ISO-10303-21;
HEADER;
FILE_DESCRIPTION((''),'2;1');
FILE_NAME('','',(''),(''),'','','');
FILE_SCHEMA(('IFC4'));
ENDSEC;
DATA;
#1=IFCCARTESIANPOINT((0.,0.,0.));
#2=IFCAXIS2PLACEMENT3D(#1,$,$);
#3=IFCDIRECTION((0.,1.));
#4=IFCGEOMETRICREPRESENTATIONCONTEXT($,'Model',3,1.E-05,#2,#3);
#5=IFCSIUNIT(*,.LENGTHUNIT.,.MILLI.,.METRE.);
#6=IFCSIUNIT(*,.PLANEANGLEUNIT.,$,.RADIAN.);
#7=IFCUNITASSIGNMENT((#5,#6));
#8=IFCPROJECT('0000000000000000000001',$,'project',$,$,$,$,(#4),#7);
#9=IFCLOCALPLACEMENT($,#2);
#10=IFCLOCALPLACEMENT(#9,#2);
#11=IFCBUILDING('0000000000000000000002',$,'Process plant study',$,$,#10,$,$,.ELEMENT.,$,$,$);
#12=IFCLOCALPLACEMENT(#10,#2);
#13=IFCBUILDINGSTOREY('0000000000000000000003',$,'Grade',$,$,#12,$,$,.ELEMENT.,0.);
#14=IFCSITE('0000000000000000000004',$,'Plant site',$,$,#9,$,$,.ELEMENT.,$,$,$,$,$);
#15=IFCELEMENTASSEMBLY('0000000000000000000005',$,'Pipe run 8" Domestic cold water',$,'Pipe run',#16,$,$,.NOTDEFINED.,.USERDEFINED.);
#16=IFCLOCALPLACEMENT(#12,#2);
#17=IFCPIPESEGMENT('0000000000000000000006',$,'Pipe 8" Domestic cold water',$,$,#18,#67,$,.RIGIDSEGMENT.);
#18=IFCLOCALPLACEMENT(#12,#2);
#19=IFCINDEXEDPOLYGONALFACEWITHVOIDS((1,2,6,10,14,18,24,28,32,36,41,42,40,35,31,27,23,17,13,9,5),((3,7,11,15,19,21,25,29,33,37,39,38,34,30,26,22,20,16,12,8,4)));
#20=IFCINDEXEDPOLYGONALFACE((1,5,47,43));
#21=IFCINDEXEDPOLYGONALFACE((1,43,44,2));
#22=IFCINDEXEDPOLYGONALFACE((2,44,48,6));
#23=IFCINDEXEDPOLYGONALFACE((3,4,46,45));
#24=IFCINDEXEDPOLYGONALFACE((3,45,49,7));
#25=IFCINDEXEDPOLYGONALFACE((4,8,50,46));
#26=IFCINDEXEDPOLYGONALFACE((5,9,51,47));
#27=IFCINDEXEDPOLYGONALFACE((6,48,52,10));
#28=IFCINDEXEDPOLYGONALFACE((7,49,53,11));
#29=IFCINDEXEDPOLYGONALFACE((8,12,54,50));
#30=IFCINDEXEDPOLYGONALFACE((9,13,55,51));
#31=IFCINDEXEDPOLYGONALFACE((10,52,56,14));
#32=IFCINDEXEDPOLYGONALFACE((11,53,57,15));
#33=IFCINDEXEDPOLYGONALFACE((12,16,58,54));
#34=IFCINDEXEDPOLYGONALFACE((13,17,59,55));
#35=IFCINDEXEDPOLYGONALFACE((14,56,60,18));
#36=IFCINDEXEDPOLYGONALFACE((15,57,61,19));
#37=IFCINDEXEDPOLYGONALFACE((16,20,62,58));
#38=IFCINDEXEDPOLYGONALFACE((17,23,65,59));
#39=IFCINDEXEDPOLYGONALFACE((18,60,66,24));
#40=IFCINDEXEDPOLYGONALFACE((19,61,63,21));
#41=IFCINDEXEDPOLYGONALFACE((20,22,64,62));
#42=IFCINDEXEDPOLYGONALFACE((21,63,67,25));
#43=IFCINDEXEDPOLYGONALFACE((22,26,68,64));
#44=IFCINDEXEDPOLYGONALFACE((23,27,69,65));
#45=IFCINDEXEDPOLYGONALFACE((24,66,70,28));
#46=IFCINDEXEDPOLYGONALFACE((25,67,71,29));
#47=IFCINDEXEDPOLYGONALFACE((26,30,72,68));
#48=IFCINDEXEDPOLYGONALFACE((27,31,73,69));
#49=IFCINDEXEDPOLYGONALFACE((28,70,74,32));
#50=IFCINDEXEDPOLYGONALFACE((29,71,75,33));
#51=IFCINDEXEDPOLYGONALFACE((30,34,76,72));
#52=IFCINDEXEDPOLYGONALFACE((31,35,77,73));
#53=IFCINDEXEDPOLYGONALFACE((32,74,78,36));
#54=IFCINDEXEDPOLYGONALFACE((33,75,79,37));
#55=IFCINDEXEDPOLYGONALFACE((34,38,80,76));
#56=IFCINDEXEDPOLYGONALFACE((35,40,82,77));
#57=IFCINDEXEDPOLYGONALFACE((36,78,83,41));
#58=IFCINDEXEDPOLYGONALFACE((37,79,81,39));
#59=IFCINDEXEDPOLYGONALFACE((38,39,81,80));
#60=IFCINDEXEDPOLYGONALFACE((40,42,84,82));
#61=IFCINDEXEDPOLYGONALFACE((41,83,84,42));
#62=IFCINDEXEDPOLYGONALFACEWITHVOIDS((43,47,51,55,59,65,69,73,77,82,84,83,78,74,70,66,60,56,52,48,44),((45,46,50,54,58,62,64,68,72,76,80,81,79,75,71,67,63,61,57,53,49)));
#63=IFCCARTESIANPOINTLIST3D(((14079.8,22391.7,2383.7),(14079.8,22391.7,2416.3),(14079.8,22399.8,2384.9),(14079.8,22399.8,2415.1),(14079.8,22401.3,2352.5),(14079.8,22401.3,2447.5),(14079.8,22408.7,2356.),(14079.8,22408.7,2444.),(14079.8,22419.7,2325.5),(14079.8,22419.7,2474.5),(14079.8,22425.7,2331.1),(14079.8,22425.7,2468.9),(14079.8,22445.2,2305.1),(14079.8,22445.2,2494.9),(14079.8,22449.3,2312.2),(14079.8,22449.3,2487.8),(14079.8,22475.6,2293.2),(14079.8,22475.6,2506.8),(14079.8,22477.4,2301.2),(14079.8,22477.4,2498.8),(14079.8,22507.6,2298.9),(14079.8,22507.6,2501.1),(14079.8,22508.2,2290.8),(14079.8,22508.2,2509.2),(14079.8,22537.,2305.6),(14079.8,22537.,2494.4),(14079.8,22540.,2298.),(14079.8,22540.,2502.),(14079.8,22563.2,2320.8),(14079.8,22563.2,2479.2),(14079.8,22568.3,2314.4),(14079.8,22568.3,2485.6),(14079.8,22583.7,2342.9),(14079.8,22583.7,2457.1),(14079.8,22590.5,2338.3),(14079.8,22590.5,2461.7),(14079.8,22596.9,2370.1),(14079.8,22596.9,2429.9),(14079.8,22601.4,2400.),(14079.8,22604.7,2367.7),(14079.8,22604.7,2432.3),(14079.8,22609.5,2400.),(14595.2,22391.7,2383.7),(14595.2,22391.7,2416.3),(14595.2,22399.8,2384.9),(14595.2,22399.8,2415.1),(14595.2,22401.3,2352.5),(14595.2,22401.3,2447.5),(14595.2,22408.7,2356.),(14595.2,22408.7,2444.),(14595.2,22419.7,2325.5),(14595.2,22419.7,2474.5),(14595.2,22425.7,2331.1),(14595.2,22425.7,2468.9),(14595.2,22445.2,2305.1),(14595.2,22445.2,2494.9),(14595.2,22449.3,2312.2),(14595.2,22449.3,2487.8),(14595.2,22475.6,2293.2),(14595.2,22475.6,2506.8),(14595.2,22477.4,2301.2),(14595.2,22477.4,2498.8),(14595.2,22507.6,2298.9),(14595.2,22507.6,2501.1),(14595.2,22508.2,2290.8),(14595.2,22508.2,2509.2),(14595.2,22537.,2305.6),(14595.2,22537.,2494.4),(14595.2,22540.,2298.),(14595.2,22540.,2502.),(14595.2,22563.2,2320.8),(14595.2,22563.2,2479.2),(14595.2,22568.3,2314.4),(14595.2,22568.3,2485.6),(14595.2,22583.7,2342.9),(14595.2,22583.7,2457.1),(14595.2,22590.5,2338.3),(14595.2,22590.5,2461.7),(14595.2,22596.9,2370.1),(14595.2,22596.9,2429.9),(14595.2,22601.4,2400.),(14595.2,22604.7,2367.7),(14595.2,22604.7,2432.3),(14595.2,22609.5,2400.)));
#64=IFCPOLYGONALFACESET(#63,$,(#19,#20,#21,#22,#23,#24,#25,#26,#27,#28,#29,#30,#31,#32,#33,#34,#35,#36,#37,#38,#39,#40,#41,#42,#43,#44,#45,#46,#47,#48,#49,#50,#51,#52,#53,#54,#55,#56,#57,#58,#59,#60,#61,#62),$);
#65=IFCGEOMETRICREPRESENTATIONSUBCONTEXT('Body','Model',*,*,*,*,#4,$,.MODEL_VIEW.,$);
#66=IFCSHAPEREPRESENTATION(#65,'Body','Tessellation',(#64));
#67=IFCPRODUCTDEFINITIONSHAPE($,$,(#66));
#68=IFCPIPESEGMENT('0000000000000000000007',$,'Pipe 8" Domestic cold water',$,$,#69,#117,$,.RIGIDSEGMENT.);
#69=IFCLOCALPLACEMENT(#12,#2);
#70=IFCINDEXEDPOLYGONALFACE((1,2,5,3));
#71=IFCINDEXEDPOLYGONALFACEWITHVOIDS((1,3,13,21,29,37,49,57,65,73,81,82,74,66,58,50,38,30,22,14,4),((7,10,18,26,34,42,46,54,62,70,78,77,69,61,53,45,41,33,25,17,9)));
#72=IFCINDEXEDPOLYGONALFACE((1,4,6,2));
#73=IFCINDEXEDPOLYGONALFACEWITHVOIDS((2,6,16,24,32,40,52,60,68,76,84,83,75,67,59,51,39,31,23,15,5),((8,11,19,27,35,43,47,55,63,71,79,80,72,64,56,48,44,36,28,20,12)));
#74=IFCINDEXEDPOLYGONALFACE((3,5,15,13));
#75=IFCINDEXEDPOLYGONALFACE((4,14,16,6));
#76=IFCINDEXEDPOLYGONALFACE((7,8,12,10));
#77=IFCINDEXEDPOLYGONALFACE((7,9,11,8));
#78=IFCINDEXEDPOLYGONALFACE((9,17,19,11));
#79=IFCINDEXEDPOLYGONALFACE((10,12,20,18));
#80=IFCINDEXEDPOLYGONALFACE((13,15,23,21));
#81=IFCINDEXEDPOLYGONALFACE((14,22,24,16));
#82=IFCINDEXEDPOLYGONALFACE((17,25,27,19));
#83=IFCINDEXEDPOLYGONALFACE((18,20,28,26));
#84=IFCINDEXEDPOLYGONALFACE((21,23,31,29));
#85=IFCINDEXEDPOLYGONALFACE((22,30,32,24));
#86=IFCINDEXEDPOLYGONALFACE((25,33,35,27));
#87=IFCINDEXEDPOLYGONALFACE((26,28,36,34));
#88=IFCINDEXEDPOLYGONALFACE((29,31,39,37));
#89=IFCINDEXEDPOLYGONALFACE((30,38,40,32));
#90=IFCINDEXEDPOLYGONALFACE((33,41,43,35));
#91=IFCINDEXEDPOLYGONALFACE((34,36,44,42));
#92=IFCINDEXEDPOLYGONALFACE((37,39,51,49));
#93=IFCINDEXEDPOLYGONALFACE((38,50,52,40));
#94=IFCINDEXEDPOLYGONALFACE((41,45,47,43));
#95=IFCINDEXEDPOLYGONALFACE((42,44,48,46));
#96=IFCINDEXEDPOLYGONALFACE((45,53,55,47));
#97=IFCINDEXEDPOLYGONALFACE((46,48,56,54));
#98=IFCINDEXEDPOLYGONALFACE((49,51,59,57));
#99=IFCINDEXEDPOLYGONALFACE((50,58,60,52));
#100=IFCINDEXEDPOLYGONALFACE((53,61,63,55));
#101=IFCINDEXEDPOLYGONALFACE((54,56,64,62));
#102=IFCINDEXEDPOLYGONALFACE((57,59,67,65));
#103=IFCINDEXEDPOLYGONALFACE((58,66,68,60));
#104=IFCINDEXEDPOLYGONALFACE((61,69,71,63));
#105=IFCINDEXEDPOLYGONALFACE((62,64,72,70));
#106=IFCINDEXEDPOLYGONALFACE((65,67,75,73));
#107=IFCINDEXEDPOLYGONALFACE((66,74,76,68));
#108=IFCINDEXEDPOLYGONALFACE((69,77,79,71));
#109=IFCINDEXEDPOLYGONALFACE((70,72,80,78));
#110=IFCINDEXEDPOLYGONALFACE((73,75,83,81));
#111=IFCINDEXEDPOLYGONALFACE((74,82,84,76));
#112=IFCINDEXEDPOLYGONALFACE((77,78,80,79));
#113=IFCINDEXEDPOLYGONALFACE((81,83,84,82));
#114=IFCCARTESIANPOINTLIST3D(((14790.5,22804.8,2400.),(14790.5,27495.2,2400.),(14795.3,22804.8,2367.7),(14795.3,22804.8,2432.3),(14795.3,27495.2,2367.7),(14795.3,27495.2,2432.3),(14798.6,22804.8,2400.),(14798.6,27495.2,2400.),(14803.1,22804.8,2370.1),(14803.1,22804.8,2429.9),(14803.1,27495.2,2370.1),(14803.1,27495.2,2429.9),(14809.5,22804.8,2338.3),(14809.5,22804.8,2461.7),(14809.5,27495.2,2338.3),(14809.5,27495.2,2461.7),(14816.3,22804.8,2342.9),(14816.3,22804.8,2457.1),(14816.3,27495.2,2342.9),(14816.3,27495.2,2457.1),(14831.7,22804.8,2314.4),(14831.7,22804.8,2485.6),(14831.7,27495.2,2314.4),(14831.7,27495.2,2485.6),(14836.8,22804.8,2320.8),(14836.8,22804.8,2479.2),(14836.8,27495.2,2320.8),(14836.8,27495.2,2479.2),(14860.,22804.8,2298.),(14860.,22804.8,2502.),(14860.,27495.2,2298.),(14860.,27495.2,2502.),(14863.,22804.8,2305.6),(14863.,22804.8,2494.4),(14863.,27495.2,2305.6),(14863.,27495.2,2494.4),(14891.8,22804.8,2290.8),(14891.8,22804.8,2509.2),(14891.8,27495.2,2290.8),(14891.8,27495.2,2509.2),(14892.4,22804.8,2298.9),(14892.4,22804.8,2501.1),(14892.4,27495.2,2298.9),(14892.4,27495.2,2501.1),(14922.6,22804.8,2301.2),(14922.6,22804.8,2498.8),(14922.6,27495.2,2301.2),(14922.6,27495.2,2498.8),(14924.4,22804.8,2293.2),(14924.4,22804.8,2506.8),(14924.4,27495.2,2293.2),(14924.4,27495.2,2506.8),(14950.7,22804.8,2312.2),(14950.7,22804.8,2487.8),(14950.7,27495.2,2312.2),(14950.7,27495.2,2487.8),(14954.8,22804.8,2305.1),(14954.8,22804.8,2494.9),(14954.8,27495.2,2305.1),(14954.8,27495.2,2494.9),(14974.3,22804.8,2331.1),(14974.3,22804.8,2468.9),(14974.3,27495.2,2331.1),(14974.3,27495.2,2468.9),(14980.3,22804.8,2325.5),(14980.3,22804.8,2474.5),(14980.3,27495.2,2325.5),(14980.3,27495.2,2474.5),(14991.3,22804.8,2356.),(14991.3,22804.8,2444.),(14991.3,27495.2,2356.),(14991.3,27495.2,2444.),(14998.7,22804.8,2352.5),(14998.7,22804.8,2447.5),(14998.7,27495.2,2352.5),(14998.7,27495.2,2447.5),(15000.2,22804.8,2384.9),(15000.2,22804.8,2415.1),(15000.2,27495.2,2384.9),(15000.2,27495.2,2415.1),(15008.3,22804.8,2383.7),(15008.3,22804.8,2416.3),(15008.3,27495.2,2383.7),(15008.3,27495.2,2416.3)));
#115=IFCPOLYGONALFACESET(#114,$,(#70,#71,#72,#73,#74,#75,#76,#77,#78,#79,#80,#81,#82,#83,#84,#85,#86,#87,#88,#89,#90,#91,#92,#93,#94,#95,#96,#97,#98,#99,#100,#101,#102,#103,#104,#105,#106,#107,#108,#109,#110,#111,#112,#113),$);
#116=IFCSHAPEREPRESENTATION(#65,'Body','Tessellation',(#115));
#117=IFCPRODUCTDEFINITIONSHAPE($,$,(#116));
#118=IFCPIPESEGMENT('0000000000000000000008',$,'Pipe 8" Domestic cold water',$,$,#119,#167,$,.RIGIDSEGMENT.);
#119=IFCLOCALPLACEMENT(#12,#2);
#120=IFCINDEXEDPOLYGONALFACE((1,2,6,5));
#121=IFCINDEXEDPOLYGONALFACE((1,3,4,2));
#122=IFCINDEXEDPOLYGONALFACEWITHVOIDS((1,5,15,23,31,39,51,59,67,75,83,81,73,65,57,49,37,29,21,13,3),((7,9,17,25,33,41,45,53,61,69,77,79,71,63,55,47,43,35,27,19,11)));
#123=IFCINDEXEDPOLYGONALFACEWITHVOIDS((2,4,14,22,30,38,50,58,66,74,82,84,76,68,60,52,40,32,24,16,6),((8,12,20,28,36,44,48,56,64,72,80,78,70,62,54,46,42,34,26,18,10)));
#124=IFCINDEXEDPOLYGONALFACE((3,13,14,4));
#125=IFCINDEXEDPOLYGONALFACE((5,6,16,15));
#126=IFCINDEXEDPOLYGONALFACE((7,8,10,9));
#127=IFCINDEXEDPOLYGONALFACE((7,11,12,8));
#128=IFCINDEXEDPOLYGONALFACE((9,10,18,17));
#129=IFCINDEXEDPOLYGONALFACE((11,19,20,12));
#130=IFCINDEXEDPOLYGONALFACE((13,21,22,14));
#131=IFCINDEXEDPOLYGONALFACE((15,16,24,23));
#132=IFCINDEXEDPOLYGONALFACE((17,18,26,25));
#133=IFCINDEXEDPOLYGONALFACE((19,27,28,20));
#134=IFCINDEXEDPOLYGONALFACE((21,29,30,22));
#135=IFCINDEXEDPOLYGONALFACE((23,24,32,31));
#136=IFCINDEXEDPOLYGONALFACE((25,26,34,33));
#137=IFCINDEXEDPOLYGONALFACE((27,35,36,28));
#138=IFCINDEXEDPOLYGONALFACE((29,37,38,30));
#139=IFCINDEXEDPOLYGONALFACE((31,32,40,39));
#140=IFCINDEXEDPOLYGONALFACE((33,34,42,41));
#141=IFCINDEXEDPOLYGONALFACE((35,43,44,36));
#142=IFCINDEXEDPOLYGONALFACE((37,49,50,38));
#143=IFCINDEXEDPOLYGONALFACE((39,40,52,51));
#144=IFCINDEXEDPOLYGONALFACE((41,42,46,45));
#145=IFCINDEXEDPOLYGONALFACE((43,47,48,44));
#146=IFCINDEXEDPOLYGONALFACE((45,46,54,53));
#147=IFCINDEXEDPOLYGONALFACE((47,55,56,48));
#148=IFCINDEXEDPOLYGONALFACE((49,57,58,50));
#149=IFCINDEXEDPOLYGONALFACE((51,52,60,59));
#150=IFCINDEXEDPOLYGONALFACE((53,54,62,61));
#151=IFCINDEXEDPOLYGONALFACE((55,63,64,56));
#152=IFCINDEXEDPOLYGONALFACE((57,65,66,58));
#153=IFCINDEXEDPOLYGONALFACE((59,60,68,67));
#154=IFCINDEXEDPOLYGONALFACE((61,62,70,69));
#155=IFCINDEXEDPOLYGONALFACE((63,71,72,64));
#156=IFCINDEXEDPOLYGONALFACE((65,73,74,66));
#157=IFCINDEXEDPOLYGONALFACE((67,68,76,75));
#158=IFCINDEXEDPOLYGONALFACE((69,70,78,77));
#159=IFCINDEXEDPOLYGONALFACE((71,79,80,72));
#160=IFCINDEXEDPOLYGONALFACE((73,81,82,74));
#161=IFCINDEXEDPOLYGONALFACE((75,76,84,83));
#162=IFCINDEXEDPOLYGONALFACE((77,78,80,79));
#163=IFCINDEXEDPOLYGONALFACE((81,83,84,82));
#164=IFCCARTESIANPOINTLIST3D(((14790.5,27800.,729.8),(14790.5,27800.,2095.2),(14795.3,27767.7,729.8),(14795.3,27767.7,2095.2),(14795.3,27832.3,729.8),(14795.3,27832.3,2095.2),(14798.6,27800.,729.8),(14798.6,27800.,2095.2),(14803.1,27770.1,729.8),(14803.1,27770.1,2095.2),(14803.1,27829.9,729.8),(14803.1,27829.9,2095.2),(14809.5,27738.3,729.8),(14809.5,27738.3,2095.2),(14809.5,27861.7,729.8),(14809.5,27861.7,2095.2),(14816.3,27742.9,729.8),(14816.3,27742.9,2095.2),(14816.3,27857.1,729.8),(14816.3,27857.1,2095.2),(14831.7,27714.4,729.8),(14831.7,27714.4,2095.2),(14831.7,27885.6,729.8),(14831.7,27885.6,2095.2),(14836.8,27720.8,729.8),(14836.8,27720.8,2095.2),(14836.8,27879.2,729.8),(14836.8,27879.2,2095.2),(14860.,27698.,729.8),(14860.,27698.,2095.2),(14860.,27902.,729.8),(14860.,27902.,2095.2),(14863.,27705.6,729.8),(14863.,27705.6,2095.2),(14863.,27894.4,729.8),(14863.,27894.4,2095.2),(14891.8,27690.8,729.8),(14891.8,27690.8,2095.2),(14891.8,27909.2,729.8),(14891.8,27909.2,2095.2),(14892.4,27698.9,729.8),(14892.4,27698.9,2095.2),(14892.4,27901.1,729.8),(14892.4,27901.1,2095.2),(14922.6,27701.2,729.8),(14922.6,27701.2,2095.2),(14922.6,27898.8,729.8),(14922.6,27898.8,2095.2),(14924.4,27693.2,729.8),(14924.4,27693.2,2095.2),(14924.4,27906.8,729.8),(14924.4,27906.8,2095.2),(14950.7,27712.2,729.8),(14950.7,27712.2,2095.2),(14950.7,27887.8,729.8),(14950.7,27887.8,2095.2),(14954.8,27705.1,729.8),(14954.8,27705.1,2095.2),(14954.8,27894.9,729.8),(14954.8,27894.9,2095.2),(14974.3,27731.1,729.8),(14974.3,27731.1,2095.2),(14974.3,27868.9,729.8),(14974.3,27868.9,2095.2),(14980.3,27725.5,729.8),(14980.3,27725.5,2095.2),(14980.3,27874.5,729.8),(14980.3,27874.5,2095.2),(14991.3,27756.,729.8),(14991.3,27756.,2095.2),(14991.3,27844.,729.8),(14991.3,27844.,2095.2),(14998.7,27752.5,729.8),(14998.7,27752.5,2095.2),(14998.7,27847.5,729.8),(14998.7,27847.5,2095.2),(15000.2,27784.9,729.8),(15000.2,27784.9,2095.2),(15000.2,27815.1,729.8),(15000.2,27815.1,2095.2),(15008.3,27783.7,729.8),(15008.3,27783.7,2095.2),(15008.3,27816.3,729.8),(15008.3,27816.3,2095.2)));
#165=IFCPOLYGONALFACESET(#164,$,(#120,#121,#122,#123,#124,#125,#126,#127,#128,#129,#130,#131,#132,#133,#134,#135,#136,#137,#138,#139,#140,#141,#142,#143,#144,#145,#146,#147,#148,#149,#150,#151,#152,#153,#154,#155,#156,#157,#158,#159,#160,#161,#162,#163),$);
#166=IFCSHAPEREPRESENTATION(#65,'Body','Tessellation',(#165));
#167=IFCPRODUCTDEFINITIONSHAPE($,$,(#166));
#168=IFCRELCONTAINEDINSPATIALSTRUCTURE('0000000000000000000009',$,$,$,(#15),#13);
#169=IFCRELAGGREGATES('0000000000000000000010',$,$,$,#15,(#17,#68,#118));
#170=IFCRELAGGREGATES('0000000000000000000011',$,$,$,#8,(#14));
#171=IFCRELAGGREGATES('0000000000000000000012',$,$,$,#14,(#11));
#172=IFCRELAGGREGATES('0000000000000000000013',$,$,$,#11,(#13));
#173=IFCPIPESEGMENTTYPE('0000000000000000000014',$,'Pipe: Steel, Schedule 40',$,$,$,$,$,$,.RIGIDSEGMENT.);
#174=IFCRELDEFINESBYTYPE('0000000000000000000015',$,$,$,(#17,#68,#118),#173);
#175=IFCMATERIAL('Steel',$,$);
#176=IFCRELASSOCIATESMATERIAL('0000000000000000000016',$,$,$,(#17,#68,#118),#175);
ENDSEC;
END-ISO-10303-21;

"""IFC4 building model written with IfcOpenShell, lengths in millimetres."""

from ifc_helpers import new_model, si_unit, direction, frame, origin, origin_with_axes, origin_2d, place, context, subcontext, project, spatial, hollow_circle, extrude, material, type_object, element, aggregate, save


model = new_model("IFC4")

# Units and contexts
model_context = context("Model", 3, precision=1e-05, world=origin(), true_north=direction((0.0, 1.0)))
body_context = subcontext(model_context, "Body", "Model", "MODEL_VIEW")
ifc_project = project(units=[si_unit("LENGTHUNIT", "METRE", prefix="MILLI"), si_unit("PLANEANGLEUNIT", "RADIAN")], contexts=[model_context])

# Site, building, storey
site_placement = place(None, origin())
site = spatial("IfcSite", under=ifc_project, at=site_placement, Name="Plant site", CompositionType="ELEMENT")
building_placement = place(site_placement, origin())
building = spatial("IfcBuilding", under=site, at=building_placement, Name="Process plant study", CompositionType="ELEMENT")
storey_placement = place(building_placement, origin())
storey = spatial("IfcBuildingStorey", under=building, at=storey_placement, Name="Grade", CompositionType="ELEMENT", Elevation=0.0)

# Element assembly, pipe segments
assembly_1_placement = place(storey_placement, origin_with_axes())
assembly_1 = element("IfcElementAssembly", 1, at=assembly_1_placement, inside=storey, Name="Pipe run 8\" Domestic cold water", ObjectType="Pipe run", AssemblyPlace="NOTDEFINED", PredefinedType="USERDEFINED")
ifc_material = material(Name="Steel")
pipe_segment_type = type_object("IfcPipeSegmentType", Name="Pipe: Steel, Schedule 40", PredefinedType="RIGIDSEGMENT")
pipe_segment_1_placement = place(storey_placement, origin_with_axes())
pipe_segment_1 = element("IfcPipeSegment", 2, at=pipe_segment_1_placement, type_object=pipe_segment_type, material=ifc_material, Name="Pipe 8\" Domestic cold water", PredefinedType="RIGIDSEGMENT", context=body_context, shape_type="SweptSolid", body=[
    extrude(hollow_circle(Radius=109.5, WallThickness=8.2, at=origin_2d()), frame((14079.8, 22500.0, 2400.0), z_axis=(1.0, 0.0, 0.0), x_axis=(0.0, 1.0, 0.0)), (0.0, 0.0, 1.0), 515.4),
])
pipe_segment_2_placement = place(storey_placement, origin_with_axes())
pipe_segment_2 = element("IfcPipeSegment", 3, at=pipe_segment_2_placement, type_object=pipe_segment_type, material=ifc_material, Name="Pipe 8\" Domestic cold water", PredefinedType="RIGIDSEGMENT", context=body_context, shape_type="SweptSolid", body=[
    extrude(hollow_circle(Radius=109.5, WallThickness=8.2, at=origin_2d()), frame((14900.0, 22804.8, 2400.0), z_axis=(0.0, 1.0, 0.0), x_axis=(-1.0, 0.0, 0.0)), (0.0, 0.0, 1.0), 4690.4),
])
pipe_segment_3_placement = place(storey_placement, origin_with_axes())
pipe_segment_3 = element("IfcPipeSegment", 4, at=pipe_segment_3_placement, type_object=pipe_segment_type, material=ifc_material, Name="Pipe 8\" Domestic cold water", PredefinedType="RIGIDSEGMENT", context=body_context, shape_type="SweptSolid", body=[
    extrude(hollow_circle(Radius=109.5, WallThickness=8.2, at=origin_2d()), frame((14900.0, 27800.0, 2095.2), z_axis=(0.0, 0.0, -1.0), x_axis=(-1.0, 0.0, 0.0)), (0.0, 0.0, 1.0), 1365.4),
])

aggregate(assembly_1, [pipe_segment_1, pipe_segment_2, pipe_segment_3])

save(model, "model.ifc")
